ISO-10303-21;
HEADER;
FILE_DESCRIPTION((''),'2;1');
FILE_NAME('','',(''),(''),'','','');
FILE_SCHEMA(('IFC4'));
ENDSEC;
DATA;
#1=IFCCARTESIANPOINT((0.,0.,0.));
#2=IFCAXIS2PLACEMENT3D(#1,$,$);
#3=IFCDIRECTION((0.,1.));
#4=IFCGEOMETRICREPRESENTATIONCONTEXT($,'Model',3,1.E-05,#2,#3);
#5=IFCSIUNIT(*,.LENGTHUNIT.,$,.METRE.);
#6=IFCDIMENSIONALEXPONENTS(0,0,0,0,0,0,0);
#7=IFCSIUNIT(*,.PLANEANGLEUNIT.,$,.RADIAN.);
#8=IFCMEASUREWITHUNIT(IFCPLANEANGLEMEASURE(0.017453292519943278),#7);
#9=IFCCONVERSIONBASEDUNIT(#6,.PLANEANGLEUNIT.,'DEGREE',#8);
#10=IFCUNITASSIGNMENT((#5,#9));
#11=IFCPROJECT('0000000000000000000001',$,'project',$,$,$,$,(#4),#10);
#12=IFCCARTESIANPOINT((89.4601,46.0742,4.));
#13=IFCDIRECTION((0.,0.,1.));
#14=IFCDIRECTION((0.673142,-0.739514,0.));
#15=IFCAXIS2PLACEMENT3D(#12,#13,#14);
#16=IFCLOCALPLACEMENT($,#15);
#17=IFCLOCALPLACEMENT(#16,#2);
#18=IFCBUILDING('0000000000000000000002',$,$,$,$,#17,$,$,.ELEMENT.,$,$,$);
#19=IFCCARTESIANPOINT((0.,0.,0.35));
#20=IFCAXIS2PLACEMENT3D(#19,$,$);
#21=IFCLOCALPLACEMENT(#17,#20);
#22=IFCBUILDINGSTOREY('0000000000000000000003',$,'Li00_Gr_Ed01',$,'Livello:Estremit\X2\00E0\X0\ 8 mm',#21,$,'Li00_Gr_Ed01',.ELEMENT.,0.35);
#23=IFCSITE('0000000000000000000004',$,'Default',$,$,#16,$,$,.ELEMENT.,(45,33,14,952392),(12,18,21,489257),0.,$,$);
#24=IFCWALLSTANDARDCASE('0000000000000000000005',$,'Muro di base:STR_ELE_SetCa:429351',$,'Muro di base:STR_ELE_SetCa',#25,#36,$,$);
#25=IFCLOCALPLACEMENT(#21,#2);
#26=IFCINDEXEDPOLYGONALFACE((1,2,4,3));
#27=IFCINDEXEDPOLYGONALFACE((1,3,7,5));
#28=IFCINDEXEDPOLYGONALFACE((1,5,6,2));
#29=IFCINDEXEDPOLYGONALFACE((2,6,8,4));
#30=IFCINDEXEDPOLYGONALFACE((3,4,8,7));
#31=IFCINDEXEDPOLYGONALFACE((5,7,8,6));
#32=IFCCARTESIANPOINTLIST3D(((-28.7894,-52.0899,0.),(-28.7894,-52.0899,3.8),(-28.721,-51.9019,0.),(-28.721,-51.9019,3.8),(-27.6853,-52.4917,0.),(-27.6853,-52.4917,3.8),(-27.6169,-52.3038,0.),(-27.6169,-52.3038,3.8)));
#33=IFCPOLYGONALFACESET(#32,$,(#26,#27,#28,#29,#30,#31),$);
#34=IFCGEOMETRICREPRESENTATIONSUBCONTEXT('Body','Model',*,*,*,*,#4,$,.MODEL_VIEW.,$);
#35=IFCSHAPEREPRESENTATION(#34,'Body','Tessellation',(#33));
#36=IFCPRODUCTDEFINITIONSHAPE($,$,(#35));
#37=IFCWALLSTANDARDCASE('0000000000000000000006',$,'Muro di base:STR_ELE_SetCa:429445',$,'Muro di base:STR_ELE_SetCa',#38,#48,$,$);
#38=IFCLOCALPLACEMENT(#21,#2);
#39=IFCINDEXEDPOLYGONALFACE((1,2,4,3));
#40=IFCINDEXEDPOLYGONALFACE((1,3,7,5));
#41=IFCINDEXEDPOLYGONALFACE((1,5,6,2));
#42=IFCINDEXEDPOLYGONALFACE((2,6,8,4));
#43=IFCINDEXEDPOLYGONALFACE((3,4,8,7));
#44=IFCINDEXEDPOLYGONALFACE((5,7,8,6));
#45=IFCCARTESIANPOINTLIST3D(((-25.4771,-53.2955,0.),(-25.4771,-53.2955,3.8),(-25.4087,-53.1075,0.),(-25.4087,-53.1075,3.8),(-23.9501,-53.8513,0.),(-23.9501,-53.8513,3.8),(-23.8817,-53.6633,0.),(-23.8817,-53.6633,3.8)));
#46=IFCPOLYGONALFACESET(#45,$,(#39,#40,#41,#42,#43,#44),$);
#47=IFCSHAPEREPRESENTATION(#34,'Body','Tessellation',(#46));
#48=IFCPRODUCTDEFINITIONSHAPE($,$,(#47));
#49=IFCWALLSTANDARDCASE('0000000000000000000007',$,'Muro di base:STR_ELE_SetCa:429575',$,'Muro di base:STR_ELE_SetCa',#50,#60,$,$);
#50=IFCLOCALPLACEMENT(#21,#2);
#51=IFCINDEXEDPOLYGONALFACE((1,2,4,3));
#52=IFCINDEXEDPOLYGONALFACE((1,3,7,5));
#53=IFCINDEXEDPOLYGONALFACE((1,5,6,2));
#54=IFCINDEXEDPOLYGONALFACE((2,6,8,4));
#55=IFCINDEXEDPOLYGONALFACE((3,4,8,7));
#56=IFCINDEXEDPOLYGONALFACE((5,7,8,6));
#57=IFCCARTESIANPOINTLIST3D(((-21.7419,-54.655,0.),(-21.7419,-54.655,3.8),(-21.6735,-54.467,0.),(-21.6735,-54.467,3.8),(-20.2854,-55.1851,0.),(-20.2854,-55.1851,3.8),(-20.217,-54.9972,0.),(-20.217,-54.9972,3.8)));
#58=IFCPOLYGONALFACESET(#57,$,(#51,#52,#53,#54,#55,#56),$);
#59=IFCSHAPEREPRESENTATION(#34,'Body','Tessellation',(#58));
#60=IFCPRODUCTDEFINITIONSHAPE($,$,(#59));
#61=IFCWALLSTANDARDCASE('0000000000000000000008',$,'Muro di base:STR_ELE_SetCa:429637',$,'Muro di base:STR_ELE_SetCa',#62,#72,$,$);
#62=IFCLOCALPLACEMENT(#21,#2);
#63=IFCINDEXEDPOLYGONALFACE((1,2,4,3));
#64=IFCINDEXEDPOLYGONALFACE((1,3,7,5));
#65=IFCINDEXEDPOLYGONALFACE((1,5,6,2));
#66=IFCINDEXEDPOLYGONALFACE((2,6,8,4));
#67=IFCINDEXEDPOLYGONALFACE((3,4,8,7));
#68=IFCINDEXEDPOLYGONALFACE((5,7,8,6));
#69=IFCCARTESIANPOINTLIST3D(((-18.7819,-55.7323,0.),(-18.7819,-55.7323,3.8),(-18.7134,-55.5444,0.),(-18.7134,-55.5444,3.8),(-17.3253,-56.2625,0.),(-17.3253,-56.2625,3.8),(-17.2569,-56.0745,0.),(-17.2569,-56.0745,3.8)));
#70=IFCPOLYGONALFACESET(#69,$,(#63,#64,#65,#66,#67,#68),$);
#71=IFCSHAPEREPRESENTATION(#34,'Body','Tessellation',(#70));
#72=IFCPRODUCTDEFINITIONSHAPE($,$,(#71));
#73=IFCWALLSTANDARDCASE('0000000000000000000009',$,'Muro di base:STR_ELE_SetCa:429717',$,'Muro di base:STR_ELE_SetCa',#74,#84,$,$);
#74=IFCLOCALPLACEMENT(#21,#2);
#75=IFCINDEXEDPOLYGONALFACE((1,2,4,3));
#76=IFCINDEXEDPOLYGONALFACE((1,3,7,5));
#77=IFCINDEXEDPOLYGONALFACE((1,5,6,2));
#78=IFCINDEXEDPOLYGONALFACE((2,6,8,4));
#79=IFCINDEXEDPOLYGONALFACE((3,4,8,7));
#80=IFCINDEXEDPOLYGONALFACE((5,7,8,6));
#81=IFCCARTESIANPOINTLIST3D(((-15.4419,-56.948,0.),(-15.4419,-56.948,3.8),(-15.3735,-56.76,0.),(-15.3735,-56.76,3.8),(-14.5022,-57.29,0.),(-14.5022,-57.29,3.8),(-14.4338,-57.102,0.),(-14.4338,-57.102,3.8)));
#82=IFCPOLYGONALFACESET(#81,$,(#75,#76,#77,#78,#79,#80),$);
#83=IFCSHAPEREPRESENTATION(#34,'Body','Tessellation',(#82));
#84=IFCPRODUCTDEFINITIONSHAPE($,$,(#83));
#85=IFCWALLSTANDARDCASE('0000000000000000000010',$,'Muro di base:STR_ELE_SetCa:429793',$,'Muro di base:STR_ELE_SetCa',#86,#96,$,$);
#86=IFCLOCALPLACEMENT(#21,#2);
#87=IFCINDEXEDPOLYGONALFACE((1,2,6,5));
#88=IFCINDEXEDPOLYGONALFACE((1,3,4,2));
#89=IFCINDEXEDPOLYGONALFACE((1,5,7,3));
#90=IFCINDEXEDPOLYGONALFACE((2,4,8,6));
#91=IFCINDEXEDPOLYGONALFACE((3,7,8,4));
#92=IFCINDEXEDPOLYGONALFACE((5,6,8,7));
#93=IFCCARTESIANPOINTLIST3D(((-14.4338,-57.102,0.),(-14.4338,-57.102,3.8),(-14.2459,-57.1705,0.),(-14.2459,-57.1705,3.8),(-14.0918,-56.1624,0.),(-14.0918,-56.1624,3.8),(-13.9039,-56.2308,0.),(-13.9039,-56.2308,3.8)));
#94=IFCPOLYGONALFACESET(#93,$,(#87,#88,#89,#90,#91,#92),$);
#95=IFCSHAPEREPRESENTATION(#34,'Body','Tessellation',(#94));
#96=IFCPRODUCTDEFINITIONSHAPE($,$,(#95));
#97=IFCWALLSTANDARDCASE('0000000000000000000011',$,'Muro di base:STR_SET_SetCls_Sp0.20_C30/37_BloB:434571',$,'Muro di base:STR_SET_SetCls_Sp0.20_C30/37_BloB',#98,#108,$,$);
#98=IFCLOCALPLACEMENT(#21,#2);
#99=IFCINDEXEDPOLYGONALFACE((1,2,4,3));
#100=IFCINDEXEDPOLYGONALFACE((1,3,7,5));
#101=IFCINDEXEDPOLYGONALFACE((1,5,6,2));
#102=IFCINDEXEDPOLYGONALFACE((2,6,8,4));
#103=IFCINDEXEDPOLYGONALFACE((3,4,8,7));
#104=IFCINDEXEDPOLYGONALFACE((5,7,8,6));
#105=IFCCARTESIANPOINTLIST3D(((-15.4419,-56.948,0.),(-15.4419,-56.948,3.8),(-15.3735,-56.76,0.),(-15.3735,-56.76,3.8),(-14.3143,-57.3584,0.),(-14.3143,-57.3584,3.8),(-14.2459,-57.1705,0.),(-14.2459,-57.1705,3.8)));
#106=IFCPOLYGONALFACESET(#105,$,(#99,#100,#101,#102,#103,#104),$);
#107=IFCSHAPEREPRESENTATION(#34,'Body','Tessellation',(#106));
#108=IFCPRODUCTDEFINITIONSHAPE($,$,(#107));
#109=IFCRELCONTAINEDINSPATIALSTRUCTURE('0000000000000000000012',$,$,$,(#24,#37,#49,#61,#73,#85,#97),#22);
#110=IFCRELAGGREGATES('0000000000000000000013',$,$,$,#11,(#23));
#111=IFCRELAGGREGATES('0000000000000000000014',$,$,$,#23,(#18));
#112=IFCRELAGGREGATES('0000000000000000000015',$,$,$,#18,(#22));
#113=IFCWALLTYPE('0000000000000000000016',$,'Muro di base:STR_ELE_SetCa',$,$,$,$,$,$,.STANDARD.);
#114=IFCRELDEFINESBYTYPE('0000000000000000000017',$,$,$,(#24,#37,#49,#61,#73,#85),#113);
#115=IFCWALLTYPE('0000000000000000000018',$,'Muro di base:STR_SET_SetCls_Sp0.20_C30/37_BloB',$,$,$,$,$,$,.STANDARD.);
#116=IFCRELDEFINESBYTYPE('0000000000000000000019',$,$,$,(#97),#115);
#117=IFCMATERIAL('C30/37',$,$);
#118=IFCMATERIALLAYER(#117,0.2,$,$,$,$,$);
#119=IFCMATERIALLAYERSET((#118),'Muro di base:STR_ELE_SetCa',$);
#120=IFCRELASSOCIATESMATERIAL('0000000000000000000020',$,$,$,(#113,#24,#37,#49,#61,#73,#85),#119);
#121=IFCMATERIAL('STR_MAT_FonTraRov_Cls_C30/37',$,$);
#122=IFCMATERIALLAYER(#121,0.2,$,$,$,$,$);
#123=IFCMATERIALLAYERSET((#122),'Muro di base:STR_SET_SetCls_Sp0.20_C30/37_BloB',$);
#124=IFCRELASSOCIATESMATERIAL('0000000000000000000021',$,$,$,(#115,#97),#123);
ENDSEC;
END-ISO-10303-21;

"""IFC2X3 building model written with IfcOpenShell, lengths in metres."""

from ifc_helpers import new_model, entity, si_unit, converted_unit, direction, frame, frame_2d, origin, place, context, subcontext, project, spatial, rectangle, extrude, material, layer, layer_set, layer_usage, type_object, element, save


model = new_model("IFC2X3")

# Units and contexts
model_context = context("Model", 3, precision=1e-05, world=origin(), true_north=direction((0.0, 1.0)))
body_context = subcontext(model_context, "Body", "Model", "MODEL_VIEW")
ifc_project = project(units=[si_unit("LENGTHUNIT", "METRE"), converted_unit("PLANEANGLEUNIT", "DEGREE", entity("IfcPlaneAngleMeasure", 0.017453292519943278), si_unit("PLANEANGLEUNIT", "RADIAN"), dimensions=[0, 0, 0, 0, 0, 0, 0])], contexts=[model_context])

# Site, building, storey
site_placement = place(None, frame((89.4601, 46.0742, 4.0), z_axis=(0.0, 0.0, 1.0), x_axis=(0.673142, -0.739514, 0.0)))
site = spatial("IfcSite", under=ifc_project, at=site_placement, Name="Default", CompositionType="ELEMENT", RefLatitude=(45, 33, 14, 952392), RefLongitude=(12, 18, 21, 489257), RefElevation=0.0)
building_placement = place(site_placement, origin())
building = spatial("IfcBuilding", under=site, at=building_placement, CompositionType="ELEMENT")
storey_placement = place(building_placement, frame((0.0, 0.0, 0.35)))
storey = spatial("IfcBuildingStorey", under=building, at=storey_placement, Name="Li00_Gr_Ed01", ObjectType="Livello:Estremità 8 mm", LongName="Li00_Gr_Ed01", CompositionType="ELEMENT", Elevation=0.35)

# Walls
ifc_material_1 = material(Name="C30/37")
ifc_layer_1 = layer(ifc_material_1, 0.2)
ifc_layer_set_1 = layer_set([ifc_layer_1], Name="Muro di base:STR_ELE_SetCa")
ifc_layer_usage_1 = layer_usage(ifc_layer_set_1, "AXIS2", "NEGATIVE", 0.1)
wall_type_1 = type_object("IfcWallType", Name="Muro di base:STR_ELE_SetCa", PredefinedType="STANDARD", material=ifc_layer_set_1)
wall_1_placement = place(storey_placement, frame((-28.7552, -51.9959, 0.0), z_axis=(0.0, 0.0, 1.0), x_axis=(0.939693, -0.34202, 0.0)))
element("IfcWallStandardCase", 1, at=wall_1_placement, inside=storey, type_object=wall_type_1, material=ifc_layer_usage_1, Name="Muro di base:STR_ELE_SetCa:429351", ObjectType="Muro di base:STR_ELE_SetCa", context=body_context, shape_type="SweptSolid", body=[
    extrude(rectangle(XDim=1.175, YDim=0.2, at=frame_2d((0.5875, 0.0), x_axis=(-1.0, 0.0))), origin(), (0.0, 0.0, 1.0), 3.8),
])
wall_2_placement = place(storey_placement, frame((-25.4429, -53.2015, 0.0), z_axis=(0.0, 0.0, 1.0), x_axis=(0.939693, -0.34202, 0.0)))
element("IfcWallStandardCase", 2, at=wall_2_placement, inside=storey, type_object=wall_type_1, material=ifc_layer_usage_1, Name="Muro di base:STR_ELE_SetCa:429445", ObjectType="Muro di base:STR_ELE_SetCa", context=body_context, shape_type="SweptSolid", body=[
    extrude(rectangle(XDim=1.625, YDim=0.2, at=frame_2d((0.8125, 0.0), x_axis=(-1.0, 0.0))), origin(), (0.0, 0.0, 1.0), 3.8),
])
wall_3_placement = place(storey_placement, frame((-21.7077, -54.561, 0.0), z_axis=(0.0, 0.0, 1.0), x_axis=(0.939693, -0.34202, 0.0)))
element("IfcWallStandardCase", 3, at=wall_3_placement, inside=storey, type_object=wall_type_1, material=ifc_layer_usage_1, Name="Muro di base:STR_ELE_SetCa:429575", ObjectType="Muro di base:STR_ELE_SetCa", context=body_context, shape_type="SweptSolid", body=[
    extrude(rectangle(XDim=1.55, YDim=0.2, at=frame_2d((0.775, 0.0), x_axis=(-1.0, 0.0))), origin(), (0.0, 0.0, 1.0), 3.8),
])
wall_4_placement = place(storey_placement, frame((-18.7476, -55.6384, 0.0), z_axis=(0.0, 0.0, 1.0), x_axis=(0.939693, -0.34202, 0.0)))
element("IfcWallStandardCase", 4, at=wall_4_placement, inside=storey, type_object=wall_type_1, material=ifc_layer_usage_1, Name="Muro di base:STR_ELE_SetCa:429637", ObjectType="Muro di base:STR_ELE_SetCa", context=body_context, shape_type="SweptSolid", body=[
    extrude(rectangle(XDim=1.55, YDim=0.2, at=frame_2d((0.775, 0.0), x_axis=(-1.0, 0.0))), origin(), (0.0, 0.0, 1.0), 3.8),
])
wall_5_placement = place(storey_placement, frame((-15.4077, -56.854, 0.0), z_axis=(0.0, 0.0, 1.0), x_axis=(0.939694, -0.342017, 0.0)))
element("IfcWallStandardCase", 5, at=wall_5_placement, inside=storey, type_object=wall_type_1, material=ifc_layer_usage_1, Name="Muro di base:STR_ELE_SetCa:429717", ObjectType="Muro di base:STR_ELE_SetCa", context=body_context, shape_type="SweptSolid", body=[
    extrude(rectangle(XDim=1.0, YDim=0.2, at=frame_2d((0.5, 0.0), x_axis=(-1.0, 0.0))), origin(), (0.0, 0.0, 1.0), 3.8),
])
wall_6_placement = place(storey_placement, frame((-14.3398, -57.1362, 0.0), z_axis=(0.0, 0.0, 1.0), x_axis=(0.34202, 0.939693, 0.0)))
element("IfcWallStandardCase", 6, at=wall_6_placement, inside=storey, type_object=wall_type_1, material=ifc_layer_usage_1, Name="Muro di base:STR_ELE_SetCa:429793", ObjectType="Muro di base:STR_ELE_SetCa", context=body_context, shape_type="SweptSolid", body=[
    extrude(rectangle(XDim=1.0, YDim=0.2, at=frame_2d((0.5, 0.0), x_axis=(-1.0, 0.0))), origin(), (0.0, 0.0, 1.0), 3.8),
])
ifc_material_2 = material(Name="STR_MAT_FonTraRov_Cls_C30/37")
ifc_layer_2 = layer(ifc_material_2, 0.2)
ifc_layer_set_2 = layer_set([ifc_layer_2], Name="Muro di base:STR_SET_SetCls_Sp0.20_C30/37_BloB")
ifc_layer_usage_2 = layer_usage(ifc_layer_set_2, "AXIS2", "NEGATIVE", 0.1)
wall_type_2 = type_object("IfcWallType", Name="Muro di base:STR_SET_SetCls_Sp0.20_C30/37_BloB", PredefinedType="STANDARD", material=ifc_layer_set_2)
wall_7_placement = place(storey_placement, frame((-15.4077, -56.854, 0.0), z_axis=(0.0, 0.0, 1.0), x_axis=(0.939693, -0.34202, 0.0)))
element("IfcWallStandardCase", 7, at=wall_7_placement, inside=storey, type_object=wall_type_2, material=ifc_layer_usage_2, Name="Muro di base:STR_SET_SetCls_Sp0.20_C30/37_BloB:434571", ObjectType="Muro di base:STR_SET_SetCls_Sp0.20_C30/37_BloB", context=body_context, shape_type="SweptSolid", body=[
    extrude(rectangle(XDim=1.2, YDim=0.2, at=frame_2d((0.6, 0.0), x_axis=(-1.0, 0.0))), origin(), (0.0, 0.0, 1.0), 3.8),
])

save(model, "model.ifc")
